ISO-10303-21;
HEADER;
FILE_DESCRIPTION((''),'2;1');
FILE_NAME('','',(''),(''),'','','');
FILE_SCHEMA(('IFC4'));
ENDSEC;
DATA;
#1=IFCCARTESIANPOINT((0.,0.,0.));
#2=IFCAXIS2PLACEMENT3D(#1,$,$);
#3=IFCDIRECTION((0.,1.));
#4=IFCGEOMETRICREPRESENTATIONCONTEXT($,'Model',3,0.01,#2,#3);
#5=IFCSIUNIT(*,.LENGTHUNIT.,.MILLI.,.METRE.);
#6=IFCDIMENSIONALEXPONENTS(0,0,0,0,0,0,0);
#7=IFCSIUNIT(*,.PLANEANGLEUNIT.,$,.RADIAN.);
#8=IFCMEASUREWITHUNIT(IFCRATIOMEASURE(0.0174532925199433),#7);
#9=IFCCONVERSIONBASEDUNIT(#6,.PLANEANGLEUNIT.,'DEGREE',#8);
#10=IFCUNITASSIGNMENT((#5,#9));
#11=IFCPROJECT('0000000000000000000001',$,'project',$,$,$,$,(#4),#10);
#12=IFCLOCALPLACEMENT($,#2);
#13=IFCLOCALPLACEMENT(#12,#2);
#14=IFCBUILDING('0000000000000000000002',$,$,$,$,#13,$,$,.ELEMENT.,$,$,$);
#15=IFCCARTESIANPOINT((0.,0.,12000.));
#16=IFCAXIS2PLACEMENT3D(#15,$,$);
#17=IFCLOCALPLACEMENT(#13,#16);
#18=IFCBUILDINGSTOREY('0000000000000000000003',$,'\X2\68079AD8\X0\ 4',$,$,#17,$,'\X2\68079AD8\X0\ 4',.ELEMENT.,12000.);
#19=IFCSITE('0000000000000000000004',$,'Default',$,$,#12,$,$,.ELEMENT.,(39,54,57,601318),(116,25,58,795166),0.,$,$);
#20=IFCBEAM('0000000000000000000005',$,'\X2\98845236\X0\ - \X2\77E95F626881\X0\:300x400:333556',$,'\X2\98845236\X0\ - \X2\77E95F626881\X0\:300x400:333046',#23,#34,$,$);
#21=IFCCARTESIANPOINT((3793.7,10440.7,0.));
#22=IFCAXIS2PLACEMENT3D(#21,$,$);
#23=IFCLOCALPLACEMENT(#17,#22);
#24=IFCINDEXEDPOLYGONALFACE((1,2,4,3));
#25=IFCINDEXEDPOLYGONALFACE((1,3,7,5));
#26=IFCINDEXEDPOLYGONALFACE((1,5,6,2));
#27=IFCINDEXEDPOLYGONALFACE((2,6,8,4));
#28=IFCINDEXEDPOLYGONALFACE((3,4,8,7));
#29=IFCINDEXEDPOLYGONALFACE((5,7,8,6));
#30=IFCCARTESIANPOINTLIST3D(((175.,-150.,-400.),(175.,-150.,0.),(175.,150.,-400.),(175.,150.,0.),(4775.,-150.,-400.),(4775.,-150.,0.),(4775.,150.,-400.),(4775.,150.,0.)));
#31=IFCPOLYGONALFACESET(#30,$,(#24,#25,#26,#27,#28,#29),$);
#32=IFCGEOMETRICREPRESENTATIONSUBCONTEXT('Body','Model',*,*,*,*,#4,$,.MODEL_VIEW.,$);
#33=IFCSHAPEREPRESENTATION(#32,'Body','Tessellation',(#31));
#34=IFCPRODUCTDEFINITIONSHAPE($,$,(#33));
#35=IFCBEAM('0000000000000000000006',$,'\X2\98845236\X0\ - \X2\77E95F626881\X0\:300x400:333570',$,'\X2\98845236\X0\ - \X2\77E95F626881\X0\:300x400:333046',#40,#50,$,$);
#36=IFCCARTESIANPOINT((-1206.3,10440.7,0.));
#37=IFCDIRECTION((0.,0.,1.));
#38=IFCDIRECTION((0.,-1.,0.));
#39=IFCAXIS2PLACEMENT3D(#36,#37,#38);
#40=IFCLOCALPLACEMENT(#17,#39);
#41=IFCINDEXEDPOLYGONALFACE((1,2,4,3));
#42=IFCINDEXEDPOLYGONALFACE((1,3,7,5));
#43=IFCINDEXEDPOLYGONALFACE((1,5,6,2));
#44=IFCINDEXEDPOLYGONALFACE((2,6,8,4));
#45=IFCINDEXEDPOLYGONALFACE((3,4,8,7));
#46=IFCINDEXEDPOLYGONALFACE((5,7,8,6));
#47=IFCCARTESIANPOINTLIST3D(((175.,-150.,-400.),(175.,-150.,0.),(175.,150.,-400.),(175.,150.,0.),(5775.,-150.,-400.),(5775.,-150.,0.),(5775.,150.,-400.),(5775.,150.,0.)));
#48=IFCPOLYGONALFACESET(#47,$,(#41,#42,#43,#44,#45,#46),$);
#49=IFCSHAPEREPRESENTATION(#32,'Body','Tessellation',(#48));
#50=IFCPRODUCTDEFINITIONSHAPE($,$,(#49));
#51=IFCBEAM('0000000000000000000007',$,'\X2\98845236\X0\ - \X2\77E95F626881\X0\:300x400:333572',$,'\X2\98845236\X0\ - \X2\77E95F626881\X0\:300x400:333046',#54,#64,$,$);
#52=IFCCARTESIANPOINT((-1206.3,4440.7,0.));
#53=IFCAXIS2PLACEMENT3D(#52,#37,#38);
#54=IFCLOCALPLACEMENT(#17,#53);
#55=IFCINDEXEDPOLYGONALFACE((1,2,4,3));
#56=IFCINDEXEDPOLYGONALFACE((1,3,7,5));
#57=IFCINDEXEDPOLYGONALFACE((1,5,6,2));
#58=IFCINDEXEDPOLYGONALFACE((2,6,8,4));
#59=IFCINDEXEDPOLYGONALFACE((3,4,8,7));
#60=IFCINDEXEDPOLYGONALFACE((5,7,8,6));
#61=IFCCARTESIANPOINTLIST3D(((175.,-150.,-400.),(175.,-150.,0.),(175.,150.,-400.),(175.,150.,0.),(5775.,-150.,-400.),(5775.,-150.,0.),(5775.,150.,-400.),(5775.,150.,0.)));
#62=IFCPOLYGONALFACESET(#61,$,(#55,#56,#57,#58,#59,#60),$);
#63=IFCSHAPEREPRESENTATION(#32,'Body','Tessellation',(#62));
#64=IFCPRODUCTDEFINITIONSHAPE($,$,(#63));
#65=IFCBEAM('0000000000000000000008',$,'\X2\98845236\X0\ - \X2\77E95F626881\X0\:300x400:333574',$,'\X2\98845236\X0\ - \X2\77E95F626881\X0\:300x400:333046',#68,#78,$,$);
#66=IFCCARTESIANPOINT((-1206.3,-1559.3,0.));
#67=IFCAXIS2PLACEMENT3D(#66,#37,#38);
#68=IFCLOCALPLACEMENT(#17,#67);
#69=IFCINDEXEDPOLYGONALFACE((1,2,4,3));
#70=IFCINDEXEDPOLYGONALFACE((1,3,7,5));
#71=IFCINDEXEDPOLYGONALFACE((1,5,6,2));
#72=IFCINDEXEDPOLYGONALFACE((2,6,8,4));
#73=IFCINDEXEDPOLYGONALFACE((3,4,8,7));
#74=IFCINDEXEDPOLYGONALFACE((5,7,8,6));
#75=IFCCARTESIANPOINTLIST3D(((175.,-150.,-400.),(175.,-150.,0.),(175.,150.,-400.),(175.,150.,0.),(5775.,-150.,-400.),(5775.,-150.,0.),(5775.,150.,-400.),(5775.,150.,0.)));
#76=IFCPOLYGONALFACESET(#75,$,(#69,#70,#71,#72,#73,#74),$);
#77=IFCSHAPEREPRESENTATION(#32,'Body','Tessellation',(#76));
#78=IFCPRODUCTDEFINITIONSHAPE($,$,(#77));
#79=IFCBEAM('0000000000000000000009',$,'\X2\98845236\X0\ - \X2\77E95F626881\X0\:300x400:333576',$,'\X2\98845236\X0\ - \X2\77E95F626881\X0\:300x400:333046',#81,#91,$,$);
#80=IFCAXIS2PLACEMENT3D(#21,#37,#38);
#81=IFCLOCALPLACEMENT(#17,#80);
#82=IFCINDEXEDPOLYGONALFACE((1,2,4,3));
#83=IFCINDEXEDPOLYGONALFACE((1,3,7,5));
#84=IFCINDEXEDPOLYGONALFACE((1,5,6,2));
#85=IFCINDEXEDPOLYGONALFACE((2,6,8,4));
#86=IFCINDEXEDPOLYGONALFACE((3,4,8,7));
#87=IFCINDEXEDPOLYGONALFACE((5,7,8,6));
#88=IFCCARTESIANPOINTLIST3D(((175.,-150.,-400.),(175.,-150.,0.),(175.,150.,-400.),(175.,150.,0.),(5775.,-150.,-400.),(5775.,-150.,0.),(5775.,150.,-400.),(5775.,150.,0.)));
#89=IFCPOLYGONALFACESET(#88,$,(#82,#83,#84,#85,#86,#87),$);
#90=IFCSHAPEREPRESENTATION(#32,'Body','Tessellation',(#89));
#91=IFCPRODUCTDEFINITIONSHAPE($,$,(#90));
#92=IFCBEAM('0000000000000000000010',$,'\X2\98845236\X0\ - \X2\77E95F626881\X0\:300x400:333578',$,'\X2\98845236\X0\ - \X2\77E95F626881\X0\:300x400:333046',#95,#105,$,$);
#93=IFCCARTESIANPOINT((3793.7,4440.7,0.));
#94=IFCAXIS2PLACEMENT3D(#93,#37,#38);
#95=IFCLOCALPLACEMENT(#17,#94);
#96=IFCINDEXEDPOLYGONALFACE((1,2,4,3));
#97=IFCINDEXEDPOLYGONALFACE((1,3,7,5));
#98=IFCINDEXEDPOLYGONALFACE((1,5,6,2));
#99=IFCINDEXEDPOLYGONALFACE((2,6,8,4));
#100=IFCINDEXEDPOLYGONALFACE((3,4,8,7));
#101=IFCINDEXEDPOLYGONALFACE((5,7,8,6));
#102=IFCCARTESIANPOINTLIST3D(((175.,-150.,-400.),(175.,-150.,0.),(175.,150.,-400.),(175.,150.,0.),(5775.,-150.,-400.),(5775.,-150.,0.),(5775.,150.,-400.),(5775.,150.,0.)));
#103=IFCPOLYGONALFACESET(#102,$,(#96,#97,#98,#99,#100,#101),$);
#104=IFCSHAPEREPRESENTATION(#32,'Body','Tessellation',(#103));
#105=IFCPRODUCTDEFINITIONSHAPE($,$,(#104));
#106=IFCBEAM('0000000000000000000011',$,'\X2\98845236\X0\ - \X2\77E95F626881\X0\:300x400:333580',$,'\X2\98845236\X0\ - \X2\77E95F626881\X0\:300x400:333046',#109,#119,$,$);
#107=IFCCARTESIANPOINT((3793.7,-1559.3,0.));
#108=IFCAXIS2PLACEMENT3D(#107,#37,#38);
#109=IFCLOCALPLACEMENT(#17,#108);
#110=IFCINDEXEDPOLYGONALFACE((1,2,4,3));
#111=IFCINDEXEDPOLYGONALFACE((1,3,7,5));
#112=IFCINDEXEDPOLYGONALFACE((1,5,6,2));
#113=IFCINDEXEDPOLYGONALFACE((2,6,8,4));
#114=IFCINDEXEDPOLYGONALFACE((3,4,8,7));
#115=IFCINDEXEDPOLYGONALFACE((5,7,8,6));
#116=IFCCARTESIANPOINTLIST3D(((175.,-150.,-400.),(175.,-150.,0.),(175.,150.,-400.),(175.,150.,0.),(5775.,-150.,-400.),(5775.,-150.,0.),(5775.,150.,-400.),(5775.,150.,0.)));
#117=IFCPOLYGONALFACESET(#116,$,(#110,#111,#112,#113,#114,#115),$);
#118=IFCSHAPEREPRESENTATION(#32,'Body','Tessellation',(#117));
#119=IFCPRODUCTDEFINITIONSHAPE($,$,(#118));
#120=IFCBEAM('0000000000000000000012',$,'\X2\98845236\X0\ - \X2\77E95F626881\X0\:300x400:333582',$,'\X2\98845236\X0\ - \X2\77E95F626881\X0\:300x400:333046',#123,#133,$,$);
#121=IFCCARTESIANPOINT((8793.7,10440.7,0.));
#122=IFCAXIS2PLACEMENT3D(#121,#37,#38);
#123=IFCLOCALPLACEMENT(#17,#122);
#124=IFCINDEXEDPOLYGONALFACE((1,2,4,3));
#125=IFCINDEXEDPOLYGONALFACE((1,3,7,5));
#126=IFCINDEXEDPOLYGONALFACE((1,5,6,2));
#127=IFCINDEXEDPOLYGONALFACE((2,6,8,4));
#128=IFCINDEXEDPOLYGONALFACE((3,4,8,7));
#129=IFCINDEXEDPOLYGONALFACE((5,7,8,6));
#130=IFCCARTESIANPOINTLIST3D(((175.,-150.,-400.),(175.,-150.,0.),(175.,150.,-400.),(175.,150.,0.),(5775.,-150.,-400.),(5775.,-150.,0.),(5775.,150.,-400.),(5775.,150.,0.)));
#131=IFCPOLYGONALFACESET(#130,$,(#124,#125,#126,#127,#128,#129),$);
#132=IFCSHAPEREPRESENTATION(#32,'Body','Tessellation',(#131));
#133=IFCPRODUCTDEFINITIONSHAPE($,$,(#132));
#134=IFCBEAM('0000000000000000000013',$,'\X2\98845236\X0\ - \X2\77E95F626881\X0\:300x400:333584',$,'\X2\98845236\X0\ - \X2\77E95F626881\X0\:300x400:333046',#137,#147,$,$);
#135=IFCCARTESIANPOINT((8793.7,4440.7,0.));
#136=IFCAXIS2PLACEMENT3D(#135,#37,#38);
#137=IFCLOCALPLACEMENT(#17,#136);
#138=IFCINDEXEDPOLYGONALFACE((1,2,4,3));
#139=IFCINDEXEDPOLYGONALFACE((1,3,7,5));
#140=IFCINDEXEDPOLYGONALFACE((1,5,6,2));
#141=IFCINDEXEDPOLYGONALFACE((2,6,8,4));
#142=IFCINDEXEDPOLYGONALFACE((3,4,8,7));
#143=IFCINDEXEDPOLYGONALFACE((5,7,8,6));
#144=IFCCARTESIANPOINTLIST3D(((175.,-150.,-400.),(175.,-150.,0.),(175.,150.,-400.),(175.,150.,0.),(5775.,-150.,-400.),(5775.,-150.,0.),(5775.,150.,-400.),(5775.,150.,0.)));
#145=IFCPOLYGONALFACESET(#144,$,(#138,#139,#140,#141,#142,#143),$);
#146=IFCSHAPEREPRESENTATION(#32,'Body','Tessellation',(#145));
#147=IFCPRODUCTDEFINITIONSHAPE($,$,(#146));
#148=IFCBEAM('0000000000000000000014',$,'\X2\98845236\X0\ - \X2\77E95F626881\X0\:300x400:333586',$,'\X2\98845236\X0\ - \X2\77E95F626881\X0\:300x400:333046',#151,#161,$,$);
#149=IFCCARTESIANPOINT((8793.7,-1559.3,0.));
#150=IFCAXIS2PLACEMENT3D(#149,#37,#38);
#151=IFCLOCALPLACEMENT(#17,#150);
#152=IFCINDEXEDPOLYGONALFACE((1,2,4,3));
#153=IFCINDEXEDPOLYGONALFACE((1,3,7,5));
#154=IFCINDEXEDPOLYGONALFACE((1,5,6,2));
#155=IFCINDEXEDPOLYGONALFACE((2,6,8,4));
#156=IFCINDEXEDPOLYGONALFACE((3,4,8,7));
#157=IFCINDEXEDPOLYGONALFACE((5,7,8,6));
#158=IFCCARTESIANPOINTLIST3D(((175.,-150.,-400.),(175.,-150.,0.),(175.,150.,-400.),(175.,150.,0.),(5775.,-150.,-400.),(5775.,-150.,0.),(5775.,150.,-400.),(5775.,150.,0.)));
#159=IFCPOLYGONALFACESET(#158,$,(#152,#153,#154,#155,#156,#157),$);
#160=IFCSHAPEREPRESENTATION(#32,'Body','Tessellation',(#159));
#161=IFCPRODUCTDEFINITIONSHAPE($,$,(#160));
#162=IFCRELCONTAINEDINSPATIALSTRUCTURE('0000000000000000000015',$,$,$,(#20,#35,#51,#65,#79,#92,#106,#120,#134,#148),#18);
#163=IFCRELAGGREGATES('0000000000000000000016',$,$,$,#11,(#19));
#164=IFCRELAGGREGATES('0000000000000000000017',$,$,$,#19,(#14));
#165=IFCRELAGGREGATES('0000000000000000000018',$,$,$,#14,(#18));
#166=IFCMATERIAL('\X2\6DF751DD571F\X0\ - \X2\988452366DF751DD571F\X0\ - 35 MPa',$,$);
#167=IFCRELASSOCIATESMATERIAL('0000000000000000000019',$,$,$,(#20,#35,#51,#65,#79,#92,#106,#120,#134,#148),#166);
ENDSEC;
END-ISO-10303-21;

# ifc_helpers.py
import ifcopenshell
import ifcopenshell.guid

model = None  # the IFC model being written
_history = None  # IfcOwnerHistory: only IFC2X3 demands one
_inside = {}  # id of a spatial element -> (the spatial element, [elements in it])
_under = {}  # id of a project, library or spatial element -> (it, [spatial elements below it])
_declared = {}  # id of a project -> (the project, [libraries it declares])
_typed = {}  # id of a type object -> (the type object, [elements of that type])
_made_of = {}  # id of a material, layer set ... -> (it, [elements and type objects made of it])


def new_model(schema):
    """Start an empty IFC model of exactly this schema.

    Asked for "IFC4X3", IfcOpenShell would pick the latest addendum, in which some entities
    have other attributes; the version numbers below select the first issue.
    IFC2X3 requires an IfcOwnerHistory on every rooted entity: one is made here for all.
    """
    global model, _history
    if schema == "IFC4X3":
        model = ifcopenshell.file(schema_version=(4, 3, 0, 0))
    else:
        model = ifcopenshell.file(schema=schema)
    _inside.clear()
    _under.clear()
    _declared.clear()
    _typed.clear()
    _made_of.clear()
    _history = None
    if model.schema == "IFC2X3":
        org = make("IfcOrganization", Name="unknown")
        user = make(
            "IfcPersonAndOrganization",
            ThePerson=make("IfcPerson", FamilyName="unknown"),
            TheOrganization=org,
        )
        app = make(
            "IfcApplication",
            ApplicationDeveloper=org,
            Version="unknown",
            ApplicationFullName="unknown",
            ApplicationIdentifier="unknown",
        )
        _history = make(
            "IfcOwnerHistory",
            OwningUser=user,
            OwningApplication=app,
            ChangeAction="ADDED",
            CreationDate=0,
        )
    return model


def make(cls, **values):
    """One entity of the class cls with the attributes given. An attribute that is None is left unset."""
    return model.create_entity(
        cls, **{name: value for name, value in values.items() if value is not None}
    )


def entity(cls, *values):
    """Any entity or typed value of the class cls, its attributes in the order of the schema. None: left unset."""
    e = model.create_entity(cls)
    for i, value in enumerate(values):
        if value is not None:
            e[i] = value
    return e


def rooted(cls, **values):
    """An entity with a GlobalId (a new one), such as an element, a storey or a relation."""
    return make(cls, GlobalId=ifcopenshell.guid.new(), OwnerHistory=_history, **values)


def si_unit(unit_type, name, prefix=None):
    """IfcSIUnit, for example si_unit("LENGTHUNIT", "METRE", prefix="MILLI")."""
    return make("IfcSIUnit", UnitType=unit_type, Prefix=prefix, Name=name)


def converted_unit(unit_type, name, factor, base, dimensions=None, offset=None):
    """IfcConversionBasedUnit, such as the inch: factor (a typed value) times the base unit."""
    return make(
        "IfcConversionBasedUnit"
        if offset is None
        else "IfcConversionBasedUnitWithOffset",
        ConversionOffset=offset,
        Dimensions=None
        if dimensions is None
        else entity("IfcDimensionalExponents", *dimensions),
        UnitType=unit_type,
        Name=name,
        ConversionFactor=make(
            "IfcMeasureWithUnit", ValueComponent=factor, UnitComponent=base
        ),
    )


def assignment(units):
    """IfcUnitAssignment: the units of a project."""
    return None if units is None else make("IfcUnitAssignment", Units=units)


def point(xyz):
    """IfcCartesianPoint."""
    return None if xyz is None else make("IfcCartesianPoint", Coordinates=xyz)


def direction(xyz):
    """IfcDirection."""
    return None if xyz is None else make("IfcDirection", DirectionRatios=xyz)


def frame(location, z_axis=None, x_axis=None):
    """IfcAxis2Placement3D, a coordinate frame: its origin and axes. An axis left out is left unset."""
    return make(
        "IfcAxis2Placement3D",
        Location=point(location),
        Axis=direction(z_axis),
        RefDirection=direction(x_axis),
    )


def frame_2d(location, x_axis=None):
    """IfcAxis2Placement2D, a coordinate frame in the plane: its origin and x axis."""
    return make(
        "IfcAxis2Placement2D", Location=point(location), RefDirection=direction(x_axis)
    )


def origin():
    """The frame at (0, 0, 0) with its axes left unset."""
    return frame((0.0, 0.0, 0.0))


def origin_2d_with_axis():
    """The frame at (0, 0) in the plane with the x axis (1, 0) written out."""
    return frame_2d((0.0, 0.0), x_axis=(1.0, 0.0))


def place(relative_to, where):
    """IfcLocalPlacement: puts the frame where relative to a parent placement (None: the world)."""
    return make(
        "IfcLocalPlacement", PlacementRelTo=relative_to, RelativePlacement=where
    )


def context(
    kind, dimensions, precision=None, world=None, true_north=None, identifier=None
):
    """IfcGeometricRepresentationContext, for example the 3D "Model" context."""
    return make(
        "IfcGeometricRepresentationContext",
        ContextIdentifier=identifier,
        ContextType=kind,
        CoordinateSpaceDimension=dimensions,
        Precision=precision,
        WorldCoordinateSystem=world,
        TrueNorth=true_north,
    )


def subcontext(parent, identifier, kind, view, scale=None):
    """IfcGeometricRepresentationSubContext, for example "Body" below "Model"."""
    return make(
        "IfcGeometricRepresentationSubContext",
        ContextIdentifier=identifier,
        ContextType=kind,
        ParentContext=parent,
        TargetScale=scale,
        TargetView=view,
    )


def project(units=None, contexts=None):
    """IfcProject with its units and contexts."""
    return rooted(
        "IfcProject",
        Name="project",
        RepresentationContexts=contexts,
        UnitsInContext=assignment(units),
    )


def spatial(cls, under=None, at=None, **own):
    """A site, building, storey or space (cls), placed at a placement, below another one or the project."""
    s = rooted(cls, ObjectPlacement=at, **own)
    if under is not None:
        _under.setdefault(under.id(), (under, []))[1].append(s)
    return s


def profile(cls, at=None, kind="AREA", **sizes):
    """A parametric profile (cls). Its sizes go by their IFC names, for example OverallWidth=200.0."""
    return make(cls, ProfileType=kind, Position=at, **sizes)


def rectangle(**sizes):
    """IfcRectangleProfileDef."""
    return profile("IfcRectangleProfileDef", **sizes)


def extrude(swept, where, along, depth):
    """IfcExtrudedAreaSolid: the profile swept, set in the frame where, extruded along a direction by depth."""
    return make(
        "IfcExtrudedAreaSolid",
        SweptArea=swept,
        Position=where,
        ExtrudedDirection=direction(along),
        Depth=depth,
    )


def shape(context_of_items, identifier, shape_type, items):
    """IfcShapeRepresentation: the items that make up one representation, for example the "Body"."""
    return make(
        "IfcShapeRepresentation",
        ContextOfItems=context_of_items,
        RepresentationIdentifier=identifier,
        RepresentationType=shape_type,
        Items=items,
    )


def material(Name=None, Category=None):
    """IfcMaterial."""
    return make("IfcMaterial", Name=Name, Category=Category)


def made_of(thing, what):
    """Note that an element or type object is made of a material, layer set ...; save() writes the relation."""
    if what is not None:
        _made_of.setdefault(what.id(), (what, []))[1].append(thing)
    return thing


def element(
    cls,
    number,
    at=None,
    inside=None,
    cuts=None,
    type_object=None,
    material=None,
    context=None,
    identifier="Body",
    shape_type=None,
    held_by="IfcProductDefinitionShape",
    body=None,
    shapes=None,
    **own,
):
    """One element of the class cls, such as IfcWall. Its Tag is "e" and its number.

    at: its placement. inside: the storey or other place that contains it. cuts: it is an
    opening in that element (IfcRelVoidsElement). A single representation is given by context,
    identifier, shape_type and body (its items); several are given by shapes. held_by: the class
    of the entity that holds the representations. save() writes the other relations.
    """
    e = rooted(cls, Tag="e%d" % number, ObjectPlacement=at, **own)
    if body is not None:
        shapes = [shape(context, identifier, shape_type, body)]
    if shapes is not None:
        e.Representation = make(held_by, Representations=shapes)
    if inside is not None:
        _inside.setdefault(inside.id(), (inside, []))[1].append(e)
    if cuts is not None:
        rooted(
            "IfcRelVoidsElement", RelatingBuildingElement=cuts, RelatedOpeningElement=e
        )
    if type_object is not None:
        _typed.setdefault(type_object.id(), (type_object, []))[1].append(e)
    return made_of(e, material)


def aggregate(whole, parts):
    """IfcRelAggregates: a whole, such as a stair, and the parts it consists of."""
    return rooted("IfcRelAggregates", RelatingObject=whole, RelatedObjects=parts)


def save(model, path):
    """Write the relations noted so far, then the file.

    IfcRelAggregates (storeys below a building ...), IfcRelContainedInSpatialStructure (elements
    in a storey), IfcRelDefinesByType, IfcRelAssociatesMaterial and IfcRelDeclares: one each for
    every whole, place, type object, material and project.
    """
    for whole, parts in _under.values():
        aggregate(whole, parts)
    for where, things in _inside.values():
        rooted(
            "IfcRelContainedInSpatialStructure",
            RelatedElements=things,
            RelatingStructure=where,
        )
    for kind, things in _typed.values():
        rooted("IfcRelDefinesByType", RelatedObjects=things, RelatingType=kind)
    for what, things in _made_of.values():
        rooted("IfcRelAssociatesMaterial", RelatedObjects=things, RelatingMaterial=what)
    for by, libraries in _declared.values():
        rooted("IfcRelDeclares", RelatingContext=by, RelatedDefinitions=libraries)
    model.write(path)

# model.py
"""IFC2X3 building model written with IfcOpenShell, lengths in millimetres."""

from ifc_helpers import new_model, entity, si_unit, converted_unit, direction, frame, frame_2d, origin, origin_2d_with_axis, place, context, subcontext, project, spatial, rectangle, extrude, material, element, save


model = new_model("IFC2X3")

# Units and contexts
model_context = context("Model", 3, precision=0.01, world=origin(), true_north=direction((0.0, 1.0)))
body_context = subcontext(model_context, "Body", "Model", "MODEL_VIEW")
ifc_project = project(units=[si_unit("LENGTHUNIT", "METRE", prefix="MILLI"), converted_unit("PLANEANGLEUNIT", "DEGREE", entity("IfcRatioMeasure", 0.0174532925199433), si_unit("PLANEANGLEUNIT", "RADIAN"), dimensions=[0, 0, 0, 0, 0, 0, 0])], contexts=[model_context])

# Site, building, storey
site_placement = place(None, origin())
site = spatial("IfcSite", under=ifc_project, at=site_placement, Name="Default", CompositionType="ELEMENT", RefLatitude=(39, 54, 57, 601318), RefLongitude=(116, 25, 58, 795166), RefElevation=0.0)
building_placement = place(site_placement, origin())
building = spatial("IfcBuilding", under=site, at=building_placement, CompositionType="ELEMENT")
storey_placement = place(building_placement, frame((0.0, 0.0, 12000.0)))
storey = spatial("IfcBuildingStorey", under=building, at=storey_placement, Name="标高 4", LongName="标高 4", CompositionType="ELEMENT", Elevation=12000.0)

# Shared definitions
ifc_material_1 = material(Name="混凝土 - 预制混凝土 - 35 MPa")

# Beams
beam_1_placement = place(storey_placement, frame((3793.7, 10440.7, 0.0)))
element("IfcBeam", 1, at=beam_1_placement, inside=storey, material=ifc_material_1, Name="预制 - 矩形梁:300x400:333556", ObjectType="预制 - 矩形梁:300x400:333046", context=body_context, shape_type="SweptSolid", body=[
    extrude(rectangle(XDim=400.0, YDim=300.0, at=frame_2d((0.0, 0.0), x_axis=(1.0, 0.0))), frame((175.0, 0.0, -200.0), z_axis=(1.0, 0.0, 0.0), x_axis=(0.0, 0.0, -1.0)), (0.0, 0.0, 1.0), 4600.0),
])
beam_2_placement = place(storey_placement, frame((-1206.3, 10440.7, 0.0), z_axis=(0.0, 0.0, 1.0), x_axis=(0.0, -1.0, 0.0)))
element("IfcBeam", 2, at=beam_2_placement, inside=storey, material=ifc_material_1, Name="预制 - 矩形梁:300x400:333570", ObjectType="预制 - 矩形梁:300x400:333046", context=body_context, shape_type="SweptSolid", body=[
    extrude(rectangle(XDim=400.0, YDim=300.0, at=frame_2d((0.0, 0.0), x_axis=(1.0, 0.0))), frame((175.0, 0.0, -200.0), z_axis=(1.0, 0.0, 0.0), x_axis=(0.0, 0.0, -1.0)), (0.0, 0.0, 1.0), 5600.0),
])
beam_3_placement = place(storey_placement, frame((-1206.3, 4440.7, 0.0), z_axis=(0.0, 0.0, 1.0), x_axis=(0.0, -1.0, 0.0)))
element("IfcBeam", 3, at=beam_3_placement, inside=storey, material=ifc_material_1, Name="预制 - 矩形梁:300x400:333572", ObjectType="预制 - 矩形梁:300x400:333046", context=body_context, shape_type="SweptSolid", body=[
    extrude(rectangle(XDim=400.0, YDim=300.0, at=frame_2d((0.0, 0.0), x_axis=(1.0, 0.0))), frame((175.0, 0.0, -200.0), z_axis=(1.0, 0.0, 0.0), x_axis=(0.0, 0.0, -1.0)), (0.0, 0.0, 1.0), 5600.0),
])
beam_4_placement = place(storey_placement, frame((-1206.3, -1559.3, 0.0), z_axis=(0.0, 0.0, 1.0), x_axis=(0.0, -1.0, 0.0)))
element("IfcBeam", 4, at=beam_4_placement, inside=storey, material=ifc_material_1, Name="预制 - 矩形梁:300x400:333574", ObjectType="预制 - 矩形梁:300x400:333046", context=body_context, shape_type="SweptSolid", body=[
    extrude(rectangle(XDim=400.0, YDim=300.0, at=frame_2d((0.0, 0.0), x_axis=(1.0, 0.0))), frame((175.0, 0.0, -200.0), z_axis=(1.0, 0.0, 0.0), x_axis=(0.0, 0.0, -1.0)), (0.0, 0.0, 1.0), 5600.0),
])
beam_5_placement = place(storey_placement, frame((3793.7, 10440.7, 0.0), z_axis=(0.0, 0.0, 1.0), x_axis=(0.0, -1.0, 0.0)))
element("IfcBeam", 5, at=beam_5_placement, inside=storey, material=ifc_material_1, Name="预制 - 矩形梁:300x400:333576", ObjectType="预制 - 矩形梁:300x400:333046", context=body_context, shape_type="SweptSolid", body=[
    extrude(rectangle(XDim=400.0, YDim=300.0, at=frame_2d((0.0, 0.0), x_axis=(1.0, 0.0))), frame((175.0, 0.0, -200.0), z_axis=(1.0, 0.0, 0.0), x_axis=(0.0, 0.0, -1.0)), (0.0, 0.0, 1.0), 5600.0),
])
beam_6_placement = place(storey_placement, frame((3793.7, 4440.7, 0.0), z_axis=(0.0, 0.0, 1.0), x_axis=(0.0, -1.0, 0.0)))
element("IfcBeam", 6, at=beam_6_placement, inside=storey, material=ifc_material_1, Name="预制 - 矩形梁:300x400:333578", ObjectType="预制 - 矩形梁:300x400:333046", context=body_context, shape_type="SweptSolid", body=[
    extrude(rectangle(XDim=400.0, YDim=300.0, at=origin_2d_with_axis()), frame((175.0, 0.0, -200.0), z_axis=(1.0, 0.0, 0.0), x_axis=(0.0, 0.0, -1.0)), (0.0, 0.0, 1.0), 5600.0),
])
beam_7_placement = place(storey_placement, frame((3793.7, -1559.3, 0.0), z_axis=(0.0, 0.0, 1.0), x_axis=(0.0, -1.0, 0.0)))
element("IfcBeam", 7, at=beam_7_placement, inside=storey, material=ifc_material_1, Name="预制 - 矩形梁:300x400:333580", ObjectType="预制 - 矩形梁:300x400:333046", context=body_context, shape_type="SweptSolid", body=[
    extrude(rectangle(XDim=400.0, YDim=300.0, at=frame_2d((0.0, 0.0), x_axis=(1.0, 0.0))), frame((175.0, 0.0, -200.0), z_axis=(1.0, 0.0, 0.0), x_axis=(0.0, 0.0, -1.0)), (0.0, 0.0, 1.0), 5600.0),
])
for number, where, z_axis, x_axis, name in (
    (8, (8793.7, 10440.7, 0.0), (0.0, 0.0, 1.0), (0.0, -1.0, 0.0), "预制 - 矩形梁:300x400:333582"),
    (9, (8793.7, 4440.7, 0.0), (0.0, 0.0, 1.0), (0.0, -1.0, 0.0), "预制 - 矩形梁:300x400:333584"),
    (10, (8793.7, -1559.3, 0.0), (0.0, 0.0, 1.0), (0.0, -1.0, 0.0), "预制 - 矩形梁:300x400:333586"),
):
    element("IfcBeam", number, at=place(storey_placement, frame(where, z_axis=z_axis, x_axis=x_axis)), inside=storey, material=ifc_material_1, Name=name, ObjectType="预制 - 矩形梁:300x400:333046", context=body_context, shape_type="SweptSolid", body=[
        extrude(rectangle(XDim=400.0, YDim=300.0, at=origin_2d_with_axis()), frame((175.0, 0.0, -200.0), z_axis=(1.0, 0.0, 0.0), x_axis=(0.0, 0.0, -1.0)), (0.0, 0.0, 1.0), 5600.0),
    ])

save(model, "model.ifc")
